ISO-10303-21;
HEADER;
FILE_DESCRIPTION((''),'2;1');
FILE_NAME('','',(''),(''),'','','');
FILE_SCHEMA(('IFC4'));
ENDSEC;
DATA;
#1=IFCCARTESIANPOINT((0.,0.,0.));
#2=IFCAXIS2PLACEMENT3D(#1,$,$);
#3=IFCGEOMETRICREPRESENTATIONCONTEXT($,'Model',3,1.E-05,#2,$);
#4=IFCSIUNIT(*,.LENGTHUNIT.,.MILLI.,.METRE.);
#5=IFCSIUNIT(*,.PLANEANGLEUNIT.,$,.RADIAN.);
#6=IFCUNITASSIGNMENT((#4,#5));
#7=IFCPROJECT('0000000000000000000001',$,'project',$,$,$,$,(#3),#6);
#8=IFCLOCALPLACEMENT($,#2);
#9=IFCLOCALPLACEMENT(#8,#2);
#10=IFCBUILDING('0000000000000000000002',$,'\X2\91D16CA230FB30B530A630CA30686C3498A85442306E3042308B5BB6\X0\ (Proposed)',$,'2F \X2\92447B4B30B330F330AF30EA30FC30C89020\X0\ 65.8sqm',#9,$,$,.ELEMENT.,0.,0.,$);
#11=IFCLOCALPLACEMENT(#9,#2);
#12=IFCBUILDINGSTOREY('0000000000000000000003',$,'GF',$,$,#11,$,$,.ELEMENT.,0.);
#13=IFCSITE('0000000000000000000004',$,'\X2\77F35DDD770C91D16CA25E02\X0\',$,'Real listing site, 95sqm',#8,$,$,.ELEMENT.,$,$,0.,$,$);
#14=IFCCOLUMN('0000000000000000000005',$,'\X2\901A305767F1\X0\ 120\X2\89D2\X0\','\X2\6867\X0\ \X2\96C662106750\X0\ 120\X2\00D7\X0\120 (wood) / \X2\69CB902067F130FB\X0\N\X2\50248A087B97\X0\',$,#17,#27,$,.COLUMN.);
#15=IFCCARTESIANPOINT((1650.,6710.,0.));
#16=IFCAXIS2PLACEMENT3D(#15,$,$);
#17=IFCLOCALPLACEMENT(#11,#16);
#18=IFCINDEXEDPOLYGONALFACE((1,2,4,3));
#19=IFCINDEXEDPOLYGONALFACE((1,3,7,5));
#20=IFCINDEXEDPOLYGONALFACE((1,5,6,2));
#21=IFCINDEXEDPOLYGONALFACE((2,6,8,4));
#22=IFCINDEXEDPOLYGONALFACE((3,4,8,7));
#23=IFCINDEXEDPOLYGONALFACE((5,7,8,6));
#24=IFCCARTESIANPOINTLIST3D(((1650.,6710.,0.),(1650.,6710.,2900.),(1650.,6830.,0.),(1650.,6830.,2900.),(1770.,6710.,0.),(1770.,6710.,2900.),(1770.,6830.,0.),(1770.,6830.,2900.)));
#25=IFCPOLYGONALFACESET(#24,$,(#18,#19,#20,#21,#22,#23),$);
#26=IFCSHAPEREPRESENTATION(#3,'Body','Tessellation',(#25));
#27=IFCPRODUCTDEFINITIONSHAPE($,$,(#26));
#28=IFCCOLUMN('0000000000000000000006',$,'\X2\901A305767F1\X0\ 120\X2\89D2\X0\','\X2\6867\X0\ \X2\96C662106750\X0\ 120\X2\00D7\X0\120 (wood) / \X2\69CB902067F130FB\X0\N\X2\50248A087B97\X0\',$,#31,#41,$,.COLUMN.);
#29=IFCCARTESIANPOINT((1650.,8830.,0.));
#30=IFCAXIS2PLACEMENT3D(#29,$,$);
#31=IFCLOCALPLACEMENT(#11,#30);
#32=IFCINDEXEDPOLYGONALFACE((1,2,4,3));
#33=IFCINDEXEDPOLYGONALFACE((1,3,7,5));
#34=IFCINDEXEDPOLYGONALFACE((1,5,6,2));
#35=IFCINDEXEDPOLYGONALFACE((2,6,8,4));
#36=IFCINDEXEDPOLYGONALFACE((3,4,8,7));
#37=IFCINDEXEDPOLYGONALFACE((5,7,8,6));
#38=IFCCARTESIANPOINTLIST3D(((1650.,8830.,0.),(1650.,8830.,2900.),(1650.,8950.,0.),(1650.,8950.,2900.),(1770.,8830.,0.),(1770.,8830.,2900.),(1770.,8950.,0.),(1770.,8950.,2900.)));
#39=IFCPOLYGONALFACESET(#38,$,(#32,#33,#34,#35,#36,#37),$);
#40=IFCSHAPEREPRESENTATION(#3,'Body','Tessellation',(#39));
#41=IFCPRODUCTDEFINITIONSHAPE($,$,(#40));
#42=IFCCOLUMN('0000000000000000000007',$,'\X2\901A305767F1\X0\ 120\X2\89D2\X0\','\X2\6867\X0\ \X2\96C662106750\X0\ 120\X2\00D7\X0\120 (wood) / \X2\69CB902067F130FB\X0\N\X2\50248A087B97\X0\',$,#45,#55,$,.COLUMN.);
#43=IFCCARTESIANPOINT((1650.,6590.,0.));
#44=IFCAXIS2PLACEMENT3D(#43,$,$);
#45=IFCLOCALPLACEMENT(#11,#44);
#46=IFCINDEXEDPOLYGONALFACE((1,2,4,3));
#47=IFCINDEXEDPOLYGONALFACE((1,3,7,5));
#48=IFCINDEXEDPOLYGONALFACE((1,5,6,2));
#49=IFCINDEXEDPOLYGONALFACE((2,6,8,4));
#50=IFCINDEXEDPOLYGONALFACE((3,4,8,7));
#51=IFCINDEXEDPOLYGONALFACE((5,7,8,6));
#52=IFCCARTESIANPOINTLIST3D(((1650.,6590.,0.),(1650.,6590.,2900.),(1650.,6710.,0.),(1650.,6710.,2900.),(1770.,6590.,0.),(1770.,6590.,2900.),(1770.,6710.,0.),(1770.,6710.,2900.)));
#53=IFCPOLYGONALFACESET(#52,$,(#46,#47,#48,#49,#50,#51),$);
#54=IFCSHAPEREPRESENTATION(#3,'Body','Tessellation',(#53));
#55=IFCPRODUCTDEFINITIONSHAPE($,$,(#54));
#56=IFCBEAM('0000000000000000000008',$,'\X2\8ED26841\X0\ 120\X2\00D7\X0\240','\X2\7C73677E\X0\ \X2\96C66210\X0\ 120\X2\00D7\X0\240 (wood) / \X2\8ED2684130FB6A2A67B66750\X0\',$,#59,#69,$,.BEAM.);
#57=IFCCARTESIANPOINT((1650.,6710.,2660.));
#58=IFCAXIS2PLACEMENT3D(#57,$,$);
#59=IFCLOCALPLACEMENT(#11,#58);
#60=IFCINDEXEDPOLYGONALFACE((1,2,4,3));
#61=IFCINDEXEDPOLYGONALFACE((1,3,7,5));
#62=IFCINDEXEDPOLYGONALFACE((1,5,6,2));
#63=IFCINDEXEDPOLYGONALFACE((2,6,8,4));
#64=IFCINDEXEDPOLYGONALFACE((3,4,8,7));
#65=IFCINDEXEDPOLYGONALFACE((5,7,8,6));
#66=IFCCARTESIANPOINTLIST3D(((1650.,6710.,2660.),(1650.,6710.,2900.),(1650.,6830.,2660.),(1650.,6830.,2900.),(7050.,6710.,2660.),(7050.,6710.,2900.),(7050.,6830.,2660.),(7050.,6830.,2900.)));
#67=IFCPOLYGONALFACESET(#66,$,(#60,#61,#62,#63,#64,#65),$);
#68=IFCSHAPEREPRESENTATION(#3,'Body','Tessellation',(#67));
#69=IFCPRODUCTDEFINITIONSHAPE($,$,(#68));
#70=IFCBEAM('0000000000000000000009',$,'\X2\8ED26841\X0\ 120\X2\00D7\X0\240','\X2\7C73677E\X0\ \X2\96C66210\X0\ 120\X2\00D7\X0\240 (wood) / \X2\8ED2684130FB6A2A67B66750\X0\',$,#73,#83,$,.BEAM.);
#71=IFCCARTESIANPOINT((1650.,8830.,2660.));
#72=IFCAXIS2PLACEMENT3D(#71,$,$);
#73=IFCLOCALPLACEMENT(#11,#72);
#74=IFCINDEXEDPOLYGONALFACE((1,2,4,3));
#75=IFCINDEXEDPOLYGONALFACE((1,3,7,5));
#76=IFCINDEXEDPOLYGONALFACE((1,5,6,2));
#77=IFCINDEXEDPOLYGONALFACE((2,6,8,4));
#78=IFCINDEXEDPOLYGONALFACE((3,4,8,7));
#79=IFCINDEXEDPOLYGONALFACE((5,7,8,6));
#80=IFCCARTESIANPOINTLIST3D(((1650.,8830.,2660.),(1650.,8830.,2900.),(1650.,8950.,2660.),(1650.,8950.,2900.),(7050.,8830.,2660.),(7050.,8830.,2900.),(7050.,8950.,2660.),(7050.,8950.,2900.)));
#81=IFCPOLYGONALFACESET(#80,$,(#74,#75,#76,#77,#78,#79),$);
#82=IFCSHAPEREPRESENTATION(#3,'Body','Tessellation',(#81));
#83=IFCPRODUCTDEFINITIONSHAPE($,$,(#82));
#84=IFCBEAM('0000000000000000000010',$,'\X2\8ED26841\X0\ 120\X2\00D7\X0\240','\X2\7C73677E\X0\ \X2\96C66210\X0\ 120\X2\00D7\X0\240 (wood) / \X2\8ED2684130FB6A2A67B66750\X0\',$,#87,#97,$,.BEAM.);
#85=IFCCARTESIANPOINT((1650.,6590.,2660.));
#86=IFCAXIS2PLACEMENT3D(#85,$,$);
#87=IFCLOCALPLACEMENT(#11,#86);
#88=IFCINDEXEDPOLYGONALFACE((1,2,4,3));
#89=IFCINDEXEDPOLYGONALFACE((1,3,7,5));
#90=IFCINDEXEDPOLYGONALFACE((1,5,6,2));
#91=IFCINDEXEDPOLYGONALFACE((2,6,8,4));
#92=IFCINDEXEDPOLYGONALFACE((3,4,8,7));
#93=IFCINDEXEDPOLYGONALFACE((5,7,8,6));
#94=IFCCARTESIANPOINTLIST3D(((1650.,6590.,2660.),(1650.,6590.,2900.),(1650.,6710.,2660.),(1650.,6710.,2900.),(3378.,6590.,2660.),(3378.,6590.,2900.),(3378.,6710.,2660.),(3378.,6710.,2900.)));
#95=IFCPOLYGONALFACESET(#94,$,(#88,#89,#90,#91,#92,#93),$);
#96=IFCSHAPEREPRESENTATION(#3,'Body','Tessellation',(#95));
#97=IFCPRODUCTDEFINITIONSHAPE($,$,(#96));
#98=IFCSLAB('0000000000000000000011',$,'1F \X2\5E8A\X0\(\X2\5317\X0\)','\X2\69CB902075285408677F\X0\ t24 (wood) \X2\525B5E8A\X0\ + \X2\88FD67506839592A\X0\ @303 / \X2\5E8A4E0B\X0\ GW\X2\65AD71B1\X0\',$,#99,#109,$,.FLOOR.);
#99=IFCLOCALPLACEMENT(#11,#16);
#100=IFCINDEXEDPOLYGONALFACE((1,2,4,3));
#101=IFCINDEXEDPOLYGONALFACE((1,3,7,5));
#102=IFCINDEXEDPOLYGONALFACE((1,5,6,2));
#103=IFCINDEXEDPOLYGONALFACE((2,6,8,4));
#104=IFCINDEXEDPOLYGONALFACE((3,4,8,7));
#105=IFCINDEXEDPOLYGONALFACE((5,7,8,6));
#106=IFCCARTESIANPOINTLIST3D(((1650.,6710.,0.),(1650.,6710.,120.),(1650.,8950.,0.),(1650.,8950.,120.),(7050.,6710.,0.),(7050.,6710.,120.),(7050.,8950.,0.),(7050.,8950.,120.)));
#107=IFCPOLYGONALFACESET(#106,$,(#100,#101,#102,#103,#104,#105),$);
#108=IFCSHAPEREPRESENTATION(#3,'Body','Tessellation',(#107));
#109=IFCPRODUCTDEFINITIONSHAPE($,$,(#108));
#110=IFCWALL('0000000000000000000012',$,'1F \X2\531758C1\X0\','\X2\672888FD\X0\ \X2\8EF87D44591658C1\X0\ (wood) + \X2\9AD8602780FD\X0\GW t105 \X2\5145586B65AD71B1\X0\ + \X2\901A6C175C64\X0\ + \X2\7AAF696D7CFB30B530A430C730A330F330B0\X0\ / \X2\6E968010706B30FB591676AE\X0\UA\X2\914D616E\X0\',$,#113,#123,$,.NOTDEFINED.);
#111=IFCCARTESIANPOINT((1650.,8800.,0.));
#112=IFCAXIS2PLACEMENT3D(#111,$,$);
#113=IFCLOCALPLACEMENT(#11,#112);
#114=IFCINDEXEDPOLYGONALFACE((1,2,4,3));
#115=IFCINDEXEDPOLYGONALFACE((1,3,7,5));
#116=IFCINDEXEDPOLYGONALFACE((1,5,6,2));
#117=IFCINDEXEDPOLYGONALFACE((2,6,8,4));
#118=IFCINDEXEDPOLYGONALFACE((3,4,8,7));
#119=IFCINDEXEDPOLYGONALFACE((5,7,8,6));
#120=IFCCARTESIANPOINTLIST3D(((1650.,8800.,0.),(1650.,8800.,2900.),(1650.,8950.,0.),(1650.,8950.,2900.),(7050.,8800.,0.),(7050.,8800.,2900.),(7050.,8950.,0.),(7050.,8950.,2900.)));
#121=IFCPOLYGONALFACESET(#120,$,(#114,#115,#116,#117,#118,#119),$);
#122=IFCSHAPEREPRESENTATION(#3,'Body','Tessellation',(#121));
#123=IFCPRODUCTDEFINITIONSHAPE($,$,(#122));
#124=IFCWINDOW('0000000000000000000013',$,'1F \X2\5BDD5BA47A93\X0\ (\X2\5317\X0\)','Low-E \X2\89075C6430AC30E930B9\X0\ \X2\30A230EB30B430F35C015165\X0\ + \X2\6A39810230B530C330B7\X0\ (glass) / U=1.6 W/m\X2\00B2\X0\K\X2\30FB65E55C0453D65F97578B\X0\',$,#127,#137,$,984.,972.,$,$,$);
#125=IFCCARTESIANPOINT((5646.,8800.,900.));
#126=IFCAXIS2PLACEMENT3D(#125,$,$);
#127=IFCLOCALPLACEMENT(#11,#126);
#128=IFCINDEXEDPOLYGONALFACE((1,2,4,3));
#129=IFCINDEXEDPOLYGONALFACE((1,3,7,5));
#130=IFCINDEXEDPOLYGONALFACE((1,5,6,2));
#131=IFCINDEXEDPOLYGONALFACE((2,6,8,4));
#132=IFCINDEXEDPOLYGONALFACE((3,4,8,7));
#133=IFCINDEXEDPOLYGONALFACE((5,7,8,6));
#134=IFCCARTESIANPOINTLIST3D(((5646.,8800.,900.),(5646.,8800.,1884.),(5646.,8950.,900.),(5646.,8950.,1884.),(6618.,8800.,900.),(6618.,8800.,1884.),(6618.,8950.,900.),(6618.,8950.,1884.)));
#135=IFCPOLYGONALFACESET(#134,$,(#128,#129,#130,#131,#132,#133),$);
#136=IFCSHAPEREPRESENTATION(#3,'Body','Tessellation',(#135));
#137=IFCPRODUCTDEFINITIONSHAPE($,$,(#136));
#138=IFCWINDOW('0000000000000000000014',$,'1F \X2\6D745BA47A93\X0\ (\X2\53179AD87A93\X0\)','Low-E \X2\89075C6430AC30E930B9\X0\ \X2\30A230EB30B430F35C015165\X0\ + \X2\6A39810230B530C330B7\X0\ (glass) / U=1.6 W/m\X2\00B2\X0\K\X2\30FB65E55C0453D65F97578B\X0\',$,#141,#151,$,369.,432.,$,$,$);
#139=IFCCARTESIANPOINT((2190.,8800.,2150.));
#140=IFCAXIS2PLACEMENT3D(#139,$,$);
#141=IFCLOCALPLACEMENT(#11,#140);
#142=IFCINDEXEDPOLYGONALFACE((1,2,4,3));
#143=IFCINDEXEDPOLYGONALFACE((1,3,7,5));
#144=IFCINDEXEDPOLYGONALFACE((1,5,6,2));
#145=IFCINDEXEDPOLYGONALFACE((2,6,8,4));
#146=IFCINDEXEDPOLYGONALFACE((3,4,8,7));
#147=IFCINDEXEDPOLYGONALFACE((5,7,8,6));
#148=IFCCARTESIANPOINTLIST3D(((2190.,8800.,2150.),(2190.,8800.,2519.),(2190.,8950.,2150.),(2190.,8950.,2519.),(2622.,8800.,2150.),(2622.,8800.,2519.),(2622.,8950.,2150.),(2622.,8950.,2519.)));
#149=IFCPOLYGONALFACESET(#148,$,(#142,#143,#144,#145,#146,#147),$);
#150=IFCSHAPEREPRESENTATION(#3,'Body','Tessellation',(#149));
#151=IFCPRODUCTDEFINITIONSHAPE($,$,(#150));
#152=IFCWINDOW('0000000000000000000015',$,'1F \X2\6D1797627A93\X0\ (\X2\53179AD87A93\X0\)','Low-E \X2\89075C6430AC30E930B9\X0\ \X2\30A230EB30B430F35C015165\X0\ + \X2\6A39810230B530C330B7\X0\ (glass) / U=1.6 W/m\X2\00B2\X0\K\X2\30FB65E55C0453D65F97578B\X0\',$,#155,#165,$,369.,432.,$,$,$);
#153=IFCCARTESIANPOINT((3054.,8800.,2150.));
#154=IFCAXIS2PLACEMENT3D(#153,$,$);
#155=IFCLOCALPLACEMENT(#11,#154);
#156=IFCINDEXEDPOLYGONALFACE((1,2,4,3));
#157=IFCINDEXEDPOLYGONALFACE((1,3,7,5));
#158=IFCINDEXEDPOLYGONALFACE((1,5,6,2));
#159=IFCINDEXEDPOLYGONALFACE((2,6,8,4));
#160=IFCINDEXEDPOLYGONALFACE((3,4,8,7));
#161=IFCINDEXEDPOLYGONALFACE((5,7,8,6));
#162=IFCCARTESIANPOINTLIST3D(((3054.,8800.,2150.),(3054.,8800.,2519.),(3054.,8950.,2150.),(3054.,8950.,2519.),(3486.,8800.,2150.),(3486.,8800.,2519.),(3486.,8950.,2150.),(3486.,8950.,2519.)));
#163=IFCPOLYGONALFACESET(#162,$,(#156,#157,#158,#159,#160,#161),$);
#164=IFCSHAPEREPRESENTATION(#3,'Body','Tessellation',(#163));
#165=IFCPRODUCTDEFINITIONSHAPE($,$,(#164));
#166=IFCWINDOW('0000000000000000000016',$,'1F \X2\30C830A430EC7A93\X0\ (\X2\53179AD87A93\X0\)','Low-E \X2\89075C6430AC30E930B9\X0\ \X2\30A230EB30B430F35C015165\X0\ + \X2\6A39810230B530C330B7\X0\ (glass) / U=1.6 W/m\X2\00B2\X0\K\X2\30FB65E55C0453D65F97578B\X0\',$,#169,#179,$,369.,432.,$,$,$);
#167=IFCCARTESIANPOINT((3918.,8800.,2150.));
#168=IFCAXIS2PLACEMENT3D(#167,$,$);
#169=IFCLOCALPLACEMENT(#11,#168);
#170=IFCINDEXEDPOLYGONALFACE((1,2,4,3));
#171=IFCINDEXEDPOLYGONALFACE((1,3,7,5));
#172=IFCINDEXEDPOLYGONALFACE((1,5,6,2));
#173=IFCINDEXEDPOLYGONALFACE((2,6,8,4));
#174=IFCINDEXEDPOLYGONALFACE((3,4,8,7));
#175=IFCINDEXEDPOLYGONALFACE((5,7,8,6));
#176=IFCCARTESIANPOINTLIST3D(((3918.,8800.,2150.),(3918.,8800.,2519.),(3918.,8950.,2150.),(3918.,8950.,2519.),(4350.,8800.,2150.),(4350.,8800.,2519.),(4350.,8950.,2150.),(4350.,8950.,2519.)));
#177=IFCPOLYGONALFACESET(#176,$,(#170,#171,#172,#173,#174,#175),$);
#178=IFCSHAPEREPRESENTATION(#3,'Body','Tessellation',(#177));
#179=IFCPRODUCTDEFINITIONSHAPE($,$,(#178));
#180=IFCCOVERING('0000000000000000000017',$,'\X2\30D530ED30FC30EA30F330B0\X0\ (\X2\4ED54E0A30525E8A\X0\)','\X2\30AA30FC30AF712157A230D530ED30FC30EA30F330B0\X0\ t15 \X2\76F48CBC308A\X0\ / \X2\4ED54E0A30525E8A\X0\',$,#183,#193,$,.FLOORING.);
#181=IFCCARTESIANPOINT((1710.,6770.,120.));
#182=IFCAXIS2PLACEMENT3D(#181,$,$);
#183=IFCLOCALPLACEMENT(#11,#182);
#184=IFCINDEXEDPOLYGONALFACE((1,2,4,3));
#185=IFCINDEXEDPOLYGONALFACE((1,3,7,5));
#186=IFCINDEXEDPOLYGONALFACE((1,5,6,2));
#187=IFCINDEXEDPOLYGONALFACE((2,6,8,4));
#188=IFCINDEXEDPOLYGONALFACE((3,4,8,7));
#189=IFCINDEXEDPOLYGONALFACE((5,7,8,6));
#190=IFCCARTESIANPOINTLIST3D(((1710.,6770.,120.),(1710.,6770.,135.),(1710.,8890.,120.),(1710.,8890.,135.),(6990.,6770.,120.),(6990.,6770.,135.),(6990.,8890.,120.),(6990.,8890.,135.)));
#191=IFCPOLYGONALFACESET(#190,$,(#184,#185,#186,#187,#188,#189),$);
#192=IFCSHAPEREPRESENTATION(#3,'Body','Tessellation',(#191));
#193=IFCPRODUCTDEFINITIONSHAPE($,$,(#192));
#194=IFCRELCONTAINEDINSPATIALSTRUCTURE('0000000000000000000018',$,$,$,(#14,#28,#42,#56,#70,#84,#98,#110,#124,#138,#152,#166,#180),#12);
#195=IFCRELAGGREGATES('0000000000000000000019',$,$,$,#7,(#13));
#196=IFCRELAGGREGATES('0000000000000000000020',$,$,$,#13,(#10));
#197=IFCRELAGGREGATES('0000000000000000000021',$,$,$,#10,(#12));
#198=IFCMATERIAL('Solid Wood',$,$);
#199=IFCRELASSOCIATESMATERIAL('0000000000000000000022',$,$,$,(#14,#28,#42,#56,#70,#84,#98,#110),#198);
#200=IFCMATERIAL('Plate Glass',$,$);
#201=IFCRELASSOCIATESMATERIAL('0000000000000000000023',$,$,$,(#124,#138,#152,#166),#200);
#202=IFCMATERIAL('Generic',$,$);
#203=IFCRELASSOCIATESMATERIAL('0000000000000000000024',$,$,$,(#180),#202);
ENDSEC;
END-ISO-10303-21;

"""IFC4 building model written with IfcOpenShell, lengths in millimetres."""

from ifc_helpers import new_model, si_unit, frame, frame_2d, origin, place, context, project, spatial, rectangle, extrude, material, element, fill, save


model = new_model("IFC4")

# Units and contexts
model_context = context("Model", 3, precision=1e-05, world=origin())
ifc_project = project(units=[si_unit("LENGTHUNIT", "METRE", prefix="MILLI"), si_unit("PLANEANGLEUNIT", "RADIAN")], contexts=[model_context])

# Site, building, storey
site_placement = place(None, origin())
site = spatial("IfcSite", under=ifc_project, at=site_placement, Name="石川県金沢市", ObjectType="Real listing site, 95sqm", CompositionType="ELEMENT", RefElevation=0.0)
building_placement = place(site_placement, origin())
building = spatial("IfcBuilding", under=site, at=building_placement, Name="金沢・サウナと水風呂のある家 (Proposed)", ObjectType="2F 鉄筋コンクリート造 65.8sqm", CompositionType="ELEMENT", ElevationOfRefHeight=0.0, ElevationOfTerrain=0.0)
storey_placement = place(building_placement, origin())
storey = spatial("IfcBuildingStorey", under=building, at=storey_placement, Name="GF", CompositionType="ELEMENT", Elevation=0.0)

# Columns
ifc_material_1 = material(Name="Solid Wood")
column_1_placement = place(storey_placement, frame((1650.0, 6710.0, 0.0)))
element("IfcColumn", 1, at=column_1_placement, inside=storey, material=ifc_material_1, Name="通し柱 120角", Description="桧 集成材 120×120 (wood) / 構造柱・N値計算", PredefinedType="COLUMN", context=model_context, shape_type="SweptSolid", body=[
    extrude(rectangle(XDim=120.0, YDim=120.0, at=frame_2d((60.0, 60.0))), frame((1650.0, 6710.0, 0.0)), (0.0, 0.0, 1.0), 2900.0),
])
column_2_placement = place(storey_placement, frame((1650.0, 8830.0, 0.0)))
element("IfcColumn", 2, at=column_2_placement, inside=storey, material=ifc_material_1, Name="通し柱 120角", Description="桧 集成材 120×120 (wood) / 構造柱・N値計算", PredefinedType="COLUMN", context=model_context, shape_type="SweptSolid", body=[
    extrude(rectangle(XDim=120.0, YDim=120.0, at=frame_2d((60.0, 60.0))), frame((1650.0, 8830.0, 0.0)), (0.0, 0.0, 1.0), 2900.0),
])
column_3_placement = place(storey_placement, frame((1650.0, 6590.0, 0.0)))
element("IfcColumn", 3, at=column_3_placement, inside=storey, material=ifc_material_1, Name="通し柱 120角", Description="桧 集成材 120×120 (wood) / 構造柱・N値計算", PredefinedType="COLUMN", context=model_context, shape_type="SweptSolid", body=[
    extrude(rectangle(XDim=120.0, YDim=120.0, at=frame_2d((60.0, 60.0))), frame((1650.0, 6590.0, 0.0)), (0.0, 0.0, 1.0), 2900.0),
])

# Beams
beam_1_placement = place(storey_placement, frame((1650.0, 6710.0, 2660.0)))
element("IfcBeam", 4, at=beam_1_placement, inside=storey, material=ifc_material_1, Name="軒桁 120×240", Description="米松 集成 120×240 (wood) / 軒桁・横架材", PredefinedType="BEAM", context=model_context, shape_type="SweptSolid", body=[
    extrude(rectangle(XDim=5400.0, YDim=120.0, at=frame_2d((2700.0, 60.0))), frame((1650.0, 6710.0, 2660.0)), (0.0, 0.0, 1.0), 240.0),
])
beam_2_placement = place(storey_placement, frame((1650.0, 8830.0, 2660.0)))
element("IfcBeam", 5, at=beam_2_placement, inside=storey, material=ifc_material_1, Name="軒桁 120×240", Description="米松 集成 120×240 (wood) / 軒桁・横架材", PredefinedType="BEAM", context=model_context, shape_type="SweptSolid", body=[
    extrude(rectangle(XDim=5400.0, YDim=120.0, at=frame_2d((2700.0, 60.0))), frame((1650.0, 8830.0, 2660.0)), (0.0, 0.0, 1.0), 240.0),
])
beam_3_placement = place(storey_placement, frame((1650.0, 6590.0, 2660.0)))
element("IfcBeam", 6, at=beam_3_placement, inside=storey, material=ifc_material_1, Name="軒桁 120×240", Description="米松 集成 120×240 (wood) / 軒桁・横架材", PredefinedType="BEAM", context=model_context, shape_type="SweptSolid", body=[
    extrude(rectangle(XDim=1728.0, YDim=120.0, at=frame_2d((864.0, 60.0))), frame((1650.0, 6590.0, 2660.0)), (0.0, 0.0, 1.0), 240.0),
])

# Slab
slab_placement = place(storey_placement, frame((1650.0, 6710.0, 0.0)))
element("IfcSlab", 7, at=slab_placement, inside=storey, material=ifc_material_1, Name="1F 床(北)", Description="構造用合板 t24 (wood) 剛床 + 製材根太 @303 / 床下 GW断熱", PredefinedType="FLOOR", context=model_context, shape_type="SweptSolid", body=[
    extrude(rectangle(XDim=5400.0, YDim=2240.0, at=frame_2d((2700.0, 1120.0))), frame((1650.0, 6710.0, 0.0)), (0.0, 0.0, 1.0), 120.0),
])

# Wall, openings, windows
wall_1_placement = place(storey_placement, frame((1650.0, 8800.0, 0.0)))
wall_1 = element("IfcWall", 8, at=wall_1_placement, inside=storey, material=ifc_material_1, Name="1F 北壁", Description="木製 軸組外壁 (wood) + 高性能GW t105 充填断熱 + 通気層 + 窯業系サイディング / 準耐火・外皮UA配慮", PredefinedType="NOTDEFINED", context=model_context, shape_type="SweptSolid", body=[
    extrude(rectangle(XDim=5400.0, YDim=150.0, at=frame_2d((2700.0, 75.0))), frame((1650.0, 8800.0, 0.0)), (0.0, 0.0, 1.0), 2900.0),
])
opening_1_placement = place(storey_placement, frame((5646.0, 8800.0, 900.0)))
opening_1 = element("IfcOpeningElement", 9, at=opening_1_placement, cuts=wall_1, PredefinedType="NOTDEFINED", context=model_context, shape_type="SweptSolid", body=[
    extrude(rectangle(XDim=972.0, YDim=150.0, at=frame_2d((486.0, 75.0))), frame((5646.0, 8800.0, 900.0)), (0.0, 0.0, 1.0), 984.0),
])
opening_2_placement = place(storey_placement, frame((2190.0, 8800.0, 2150.0)))
opening_2 = element("IfcOpeningElement", 10, at=opening_2_placement, cuts=wall_1, PredefinedType="NOTDEFINED", context=model_context, shape_type="SweptSolid", body=[
    extrude(rectangle(XDim=432.0, YDim=150.0, at=frame_2d((216.0, 75.0))), frame((2190.0, 8800.0, 2150.0)), (0.0, 0.0, 1.0), 369.0),
])
opening_3_placement = place(storey_placement, frame((3054.0, 8800.0, 2150.0)))
opening_3 = element("IfcOpeningElement", 11, at=opening_3_placement, cuts=wall_1, PredefinedType="NOTDEFINED", context=model_context, shape_type="SweptSolid", body=[
    extrude(rectangle(XDim=432.0, YDim=150.0, at=frame_2d((216.0, 75.0))), frame((3054.0, 8800.0, 2150.0)), (0.0, 0.0, 1.0), 369.0),
])
opening_4_placement = place(storey_placement, frame((3918.0, 8800.0, 2150.0)))
opening_4 = element("IfcOpeningElement", 12, at=opening_4_placement, cuts=wall_1, PredefinedType="NOTDEFINED", context=model_context, shape_type="SweptSolid", body=[
    extrude(rectangle(XDim=432.0, YDim=150.0, at=frame_2d((216.0, 75.0))), frame((3918.0, 8800.0, 2150.0)), (0.0, 0.0, 1.0), 369.0),
])
ifc_material_2 = material(Name="Plate Glass")
window_1_placement = place(storey_placement, frame((5646.0, 8800.0, 900.0)))
window_1 = element("IfcWindow", 13, at=window_1_placement, inside=storey, material=ifc_material_2, Name="1F 寝室窓 (北)", Description="Low-E 複層ガラス アルゴン封入 + 樹脂サッシ (glass) / U=1.6 W/m²K・日射取得型", OverallHeight=984.0, OverallWidth=972.0, context=model_context, shape_type="SweptSolid", body=[
    extrude(rectangle(XDim=972.0, YDim=150.0, at=frame_2d((486.0, 75.0))), frame((5646.0, 8800.0, 900.0)), (0.0, 0.0, 1.0), 984.0),
])
fill(opening_1, window_1)
window_2_placement = place(storey_placement, frame((2190.0, 8800.0, 2150.0)))
window_2 = element("IfcWindow", 14, at=window_2_placement, inside=storey, material=ifc_material_2, Name="1F 浴室窓 (北高窓)", Description="Low-E 複層ガラス アルゴン封入 + 樹脂サッシ (glass) / U=1.6 W/m²K・日射取得型", OverallHeight=369.0, OverallWidth=432.0, context=model_context, shape_type="SweptSolid", body=[
    extrude(rectangle(XDim=432.0, YDim=150.0, at=frame_2d((216.0, 75.0))), frame((2190.0, 8800.0, 2150.0)), (0.0, 0.0, 1.0), 369.0),
])
fill(opening_2, window_2)
window_3_placement = place(storey_placement, frame((3054.0, 8800.0, 2150.0)))
window_3 = element("IfcWindow", 15, at=window_3_placement, inside=storey, material=ifc_material_2, Name="1F 洗面窓 (北高窓)", Description="Low-E 複層ガラス アルゴン封入 + 樹脂サッシ (glass) / U=1.6 W/m²K・日射取得型", OverallHeight=369.0, OverallWidth=432.0, context=model_context, shape_type="SweptSolid", body=[
    extrude(rectangle(XDim=432.0, YDim=150.0, at=frame_2d((216.0, 75.0))), frame((3054.0, 8800.0, 2150.0)), (0.0, 0.0, 1.0), 369.0),
])
fill(opening_3, window_3)
window_4_placement = place(storey_placement, frame((3918.0, 8800.0, 2150.0)))
window_4 = element("IfcWindow", 16, at=window_4_placement, inside=storey, material=ifc_material_2, Name="1F トイレ窓 (北高窓)", Description="Low-E 複層ガラス アルゴン封入 + 樹脂サッシ (glass) / U=1.6 W/m²K・日射取得型", OverallHeight=369.0, OverallWidth=432.0, context=model_context, shape_type="SweptSolid", body=[
    extrude(rectangle(XDim=432.0, YDim=150.0, at=frame_2d((216.0, 75.0))), frame((3918.0, 8800.0, 2150.0)), (0.0, 0.0, 1.0), 369.0),
])
fill(opening_4, window_4)

# Covering
ifc_material_3 = material(Name="Generic")
covering_1_placement = place(storey_placement, frame((1710.0, 6770.0, 120.0)))
element("IfcCovering", 17, at=covering_1_placement, inside=storey, material=ifc_material_3, Name="フローリング (仕上げ床)", Description="オーク無垢フローリング t15 直貼り / 仕上げ床", PredefinedType="FLOORING", context=model_context, shape_type="SweptSolid", body=[
    extrude(rectangle(XDim=5280.0, YDim=2120.0, at=frame_2d((2640.0, 1060.0))), frame((1710.0, 6770.0, 120.0)), (0.0, 0.0, 1.0), 15.0),
])

save(model, "model.ifc")
